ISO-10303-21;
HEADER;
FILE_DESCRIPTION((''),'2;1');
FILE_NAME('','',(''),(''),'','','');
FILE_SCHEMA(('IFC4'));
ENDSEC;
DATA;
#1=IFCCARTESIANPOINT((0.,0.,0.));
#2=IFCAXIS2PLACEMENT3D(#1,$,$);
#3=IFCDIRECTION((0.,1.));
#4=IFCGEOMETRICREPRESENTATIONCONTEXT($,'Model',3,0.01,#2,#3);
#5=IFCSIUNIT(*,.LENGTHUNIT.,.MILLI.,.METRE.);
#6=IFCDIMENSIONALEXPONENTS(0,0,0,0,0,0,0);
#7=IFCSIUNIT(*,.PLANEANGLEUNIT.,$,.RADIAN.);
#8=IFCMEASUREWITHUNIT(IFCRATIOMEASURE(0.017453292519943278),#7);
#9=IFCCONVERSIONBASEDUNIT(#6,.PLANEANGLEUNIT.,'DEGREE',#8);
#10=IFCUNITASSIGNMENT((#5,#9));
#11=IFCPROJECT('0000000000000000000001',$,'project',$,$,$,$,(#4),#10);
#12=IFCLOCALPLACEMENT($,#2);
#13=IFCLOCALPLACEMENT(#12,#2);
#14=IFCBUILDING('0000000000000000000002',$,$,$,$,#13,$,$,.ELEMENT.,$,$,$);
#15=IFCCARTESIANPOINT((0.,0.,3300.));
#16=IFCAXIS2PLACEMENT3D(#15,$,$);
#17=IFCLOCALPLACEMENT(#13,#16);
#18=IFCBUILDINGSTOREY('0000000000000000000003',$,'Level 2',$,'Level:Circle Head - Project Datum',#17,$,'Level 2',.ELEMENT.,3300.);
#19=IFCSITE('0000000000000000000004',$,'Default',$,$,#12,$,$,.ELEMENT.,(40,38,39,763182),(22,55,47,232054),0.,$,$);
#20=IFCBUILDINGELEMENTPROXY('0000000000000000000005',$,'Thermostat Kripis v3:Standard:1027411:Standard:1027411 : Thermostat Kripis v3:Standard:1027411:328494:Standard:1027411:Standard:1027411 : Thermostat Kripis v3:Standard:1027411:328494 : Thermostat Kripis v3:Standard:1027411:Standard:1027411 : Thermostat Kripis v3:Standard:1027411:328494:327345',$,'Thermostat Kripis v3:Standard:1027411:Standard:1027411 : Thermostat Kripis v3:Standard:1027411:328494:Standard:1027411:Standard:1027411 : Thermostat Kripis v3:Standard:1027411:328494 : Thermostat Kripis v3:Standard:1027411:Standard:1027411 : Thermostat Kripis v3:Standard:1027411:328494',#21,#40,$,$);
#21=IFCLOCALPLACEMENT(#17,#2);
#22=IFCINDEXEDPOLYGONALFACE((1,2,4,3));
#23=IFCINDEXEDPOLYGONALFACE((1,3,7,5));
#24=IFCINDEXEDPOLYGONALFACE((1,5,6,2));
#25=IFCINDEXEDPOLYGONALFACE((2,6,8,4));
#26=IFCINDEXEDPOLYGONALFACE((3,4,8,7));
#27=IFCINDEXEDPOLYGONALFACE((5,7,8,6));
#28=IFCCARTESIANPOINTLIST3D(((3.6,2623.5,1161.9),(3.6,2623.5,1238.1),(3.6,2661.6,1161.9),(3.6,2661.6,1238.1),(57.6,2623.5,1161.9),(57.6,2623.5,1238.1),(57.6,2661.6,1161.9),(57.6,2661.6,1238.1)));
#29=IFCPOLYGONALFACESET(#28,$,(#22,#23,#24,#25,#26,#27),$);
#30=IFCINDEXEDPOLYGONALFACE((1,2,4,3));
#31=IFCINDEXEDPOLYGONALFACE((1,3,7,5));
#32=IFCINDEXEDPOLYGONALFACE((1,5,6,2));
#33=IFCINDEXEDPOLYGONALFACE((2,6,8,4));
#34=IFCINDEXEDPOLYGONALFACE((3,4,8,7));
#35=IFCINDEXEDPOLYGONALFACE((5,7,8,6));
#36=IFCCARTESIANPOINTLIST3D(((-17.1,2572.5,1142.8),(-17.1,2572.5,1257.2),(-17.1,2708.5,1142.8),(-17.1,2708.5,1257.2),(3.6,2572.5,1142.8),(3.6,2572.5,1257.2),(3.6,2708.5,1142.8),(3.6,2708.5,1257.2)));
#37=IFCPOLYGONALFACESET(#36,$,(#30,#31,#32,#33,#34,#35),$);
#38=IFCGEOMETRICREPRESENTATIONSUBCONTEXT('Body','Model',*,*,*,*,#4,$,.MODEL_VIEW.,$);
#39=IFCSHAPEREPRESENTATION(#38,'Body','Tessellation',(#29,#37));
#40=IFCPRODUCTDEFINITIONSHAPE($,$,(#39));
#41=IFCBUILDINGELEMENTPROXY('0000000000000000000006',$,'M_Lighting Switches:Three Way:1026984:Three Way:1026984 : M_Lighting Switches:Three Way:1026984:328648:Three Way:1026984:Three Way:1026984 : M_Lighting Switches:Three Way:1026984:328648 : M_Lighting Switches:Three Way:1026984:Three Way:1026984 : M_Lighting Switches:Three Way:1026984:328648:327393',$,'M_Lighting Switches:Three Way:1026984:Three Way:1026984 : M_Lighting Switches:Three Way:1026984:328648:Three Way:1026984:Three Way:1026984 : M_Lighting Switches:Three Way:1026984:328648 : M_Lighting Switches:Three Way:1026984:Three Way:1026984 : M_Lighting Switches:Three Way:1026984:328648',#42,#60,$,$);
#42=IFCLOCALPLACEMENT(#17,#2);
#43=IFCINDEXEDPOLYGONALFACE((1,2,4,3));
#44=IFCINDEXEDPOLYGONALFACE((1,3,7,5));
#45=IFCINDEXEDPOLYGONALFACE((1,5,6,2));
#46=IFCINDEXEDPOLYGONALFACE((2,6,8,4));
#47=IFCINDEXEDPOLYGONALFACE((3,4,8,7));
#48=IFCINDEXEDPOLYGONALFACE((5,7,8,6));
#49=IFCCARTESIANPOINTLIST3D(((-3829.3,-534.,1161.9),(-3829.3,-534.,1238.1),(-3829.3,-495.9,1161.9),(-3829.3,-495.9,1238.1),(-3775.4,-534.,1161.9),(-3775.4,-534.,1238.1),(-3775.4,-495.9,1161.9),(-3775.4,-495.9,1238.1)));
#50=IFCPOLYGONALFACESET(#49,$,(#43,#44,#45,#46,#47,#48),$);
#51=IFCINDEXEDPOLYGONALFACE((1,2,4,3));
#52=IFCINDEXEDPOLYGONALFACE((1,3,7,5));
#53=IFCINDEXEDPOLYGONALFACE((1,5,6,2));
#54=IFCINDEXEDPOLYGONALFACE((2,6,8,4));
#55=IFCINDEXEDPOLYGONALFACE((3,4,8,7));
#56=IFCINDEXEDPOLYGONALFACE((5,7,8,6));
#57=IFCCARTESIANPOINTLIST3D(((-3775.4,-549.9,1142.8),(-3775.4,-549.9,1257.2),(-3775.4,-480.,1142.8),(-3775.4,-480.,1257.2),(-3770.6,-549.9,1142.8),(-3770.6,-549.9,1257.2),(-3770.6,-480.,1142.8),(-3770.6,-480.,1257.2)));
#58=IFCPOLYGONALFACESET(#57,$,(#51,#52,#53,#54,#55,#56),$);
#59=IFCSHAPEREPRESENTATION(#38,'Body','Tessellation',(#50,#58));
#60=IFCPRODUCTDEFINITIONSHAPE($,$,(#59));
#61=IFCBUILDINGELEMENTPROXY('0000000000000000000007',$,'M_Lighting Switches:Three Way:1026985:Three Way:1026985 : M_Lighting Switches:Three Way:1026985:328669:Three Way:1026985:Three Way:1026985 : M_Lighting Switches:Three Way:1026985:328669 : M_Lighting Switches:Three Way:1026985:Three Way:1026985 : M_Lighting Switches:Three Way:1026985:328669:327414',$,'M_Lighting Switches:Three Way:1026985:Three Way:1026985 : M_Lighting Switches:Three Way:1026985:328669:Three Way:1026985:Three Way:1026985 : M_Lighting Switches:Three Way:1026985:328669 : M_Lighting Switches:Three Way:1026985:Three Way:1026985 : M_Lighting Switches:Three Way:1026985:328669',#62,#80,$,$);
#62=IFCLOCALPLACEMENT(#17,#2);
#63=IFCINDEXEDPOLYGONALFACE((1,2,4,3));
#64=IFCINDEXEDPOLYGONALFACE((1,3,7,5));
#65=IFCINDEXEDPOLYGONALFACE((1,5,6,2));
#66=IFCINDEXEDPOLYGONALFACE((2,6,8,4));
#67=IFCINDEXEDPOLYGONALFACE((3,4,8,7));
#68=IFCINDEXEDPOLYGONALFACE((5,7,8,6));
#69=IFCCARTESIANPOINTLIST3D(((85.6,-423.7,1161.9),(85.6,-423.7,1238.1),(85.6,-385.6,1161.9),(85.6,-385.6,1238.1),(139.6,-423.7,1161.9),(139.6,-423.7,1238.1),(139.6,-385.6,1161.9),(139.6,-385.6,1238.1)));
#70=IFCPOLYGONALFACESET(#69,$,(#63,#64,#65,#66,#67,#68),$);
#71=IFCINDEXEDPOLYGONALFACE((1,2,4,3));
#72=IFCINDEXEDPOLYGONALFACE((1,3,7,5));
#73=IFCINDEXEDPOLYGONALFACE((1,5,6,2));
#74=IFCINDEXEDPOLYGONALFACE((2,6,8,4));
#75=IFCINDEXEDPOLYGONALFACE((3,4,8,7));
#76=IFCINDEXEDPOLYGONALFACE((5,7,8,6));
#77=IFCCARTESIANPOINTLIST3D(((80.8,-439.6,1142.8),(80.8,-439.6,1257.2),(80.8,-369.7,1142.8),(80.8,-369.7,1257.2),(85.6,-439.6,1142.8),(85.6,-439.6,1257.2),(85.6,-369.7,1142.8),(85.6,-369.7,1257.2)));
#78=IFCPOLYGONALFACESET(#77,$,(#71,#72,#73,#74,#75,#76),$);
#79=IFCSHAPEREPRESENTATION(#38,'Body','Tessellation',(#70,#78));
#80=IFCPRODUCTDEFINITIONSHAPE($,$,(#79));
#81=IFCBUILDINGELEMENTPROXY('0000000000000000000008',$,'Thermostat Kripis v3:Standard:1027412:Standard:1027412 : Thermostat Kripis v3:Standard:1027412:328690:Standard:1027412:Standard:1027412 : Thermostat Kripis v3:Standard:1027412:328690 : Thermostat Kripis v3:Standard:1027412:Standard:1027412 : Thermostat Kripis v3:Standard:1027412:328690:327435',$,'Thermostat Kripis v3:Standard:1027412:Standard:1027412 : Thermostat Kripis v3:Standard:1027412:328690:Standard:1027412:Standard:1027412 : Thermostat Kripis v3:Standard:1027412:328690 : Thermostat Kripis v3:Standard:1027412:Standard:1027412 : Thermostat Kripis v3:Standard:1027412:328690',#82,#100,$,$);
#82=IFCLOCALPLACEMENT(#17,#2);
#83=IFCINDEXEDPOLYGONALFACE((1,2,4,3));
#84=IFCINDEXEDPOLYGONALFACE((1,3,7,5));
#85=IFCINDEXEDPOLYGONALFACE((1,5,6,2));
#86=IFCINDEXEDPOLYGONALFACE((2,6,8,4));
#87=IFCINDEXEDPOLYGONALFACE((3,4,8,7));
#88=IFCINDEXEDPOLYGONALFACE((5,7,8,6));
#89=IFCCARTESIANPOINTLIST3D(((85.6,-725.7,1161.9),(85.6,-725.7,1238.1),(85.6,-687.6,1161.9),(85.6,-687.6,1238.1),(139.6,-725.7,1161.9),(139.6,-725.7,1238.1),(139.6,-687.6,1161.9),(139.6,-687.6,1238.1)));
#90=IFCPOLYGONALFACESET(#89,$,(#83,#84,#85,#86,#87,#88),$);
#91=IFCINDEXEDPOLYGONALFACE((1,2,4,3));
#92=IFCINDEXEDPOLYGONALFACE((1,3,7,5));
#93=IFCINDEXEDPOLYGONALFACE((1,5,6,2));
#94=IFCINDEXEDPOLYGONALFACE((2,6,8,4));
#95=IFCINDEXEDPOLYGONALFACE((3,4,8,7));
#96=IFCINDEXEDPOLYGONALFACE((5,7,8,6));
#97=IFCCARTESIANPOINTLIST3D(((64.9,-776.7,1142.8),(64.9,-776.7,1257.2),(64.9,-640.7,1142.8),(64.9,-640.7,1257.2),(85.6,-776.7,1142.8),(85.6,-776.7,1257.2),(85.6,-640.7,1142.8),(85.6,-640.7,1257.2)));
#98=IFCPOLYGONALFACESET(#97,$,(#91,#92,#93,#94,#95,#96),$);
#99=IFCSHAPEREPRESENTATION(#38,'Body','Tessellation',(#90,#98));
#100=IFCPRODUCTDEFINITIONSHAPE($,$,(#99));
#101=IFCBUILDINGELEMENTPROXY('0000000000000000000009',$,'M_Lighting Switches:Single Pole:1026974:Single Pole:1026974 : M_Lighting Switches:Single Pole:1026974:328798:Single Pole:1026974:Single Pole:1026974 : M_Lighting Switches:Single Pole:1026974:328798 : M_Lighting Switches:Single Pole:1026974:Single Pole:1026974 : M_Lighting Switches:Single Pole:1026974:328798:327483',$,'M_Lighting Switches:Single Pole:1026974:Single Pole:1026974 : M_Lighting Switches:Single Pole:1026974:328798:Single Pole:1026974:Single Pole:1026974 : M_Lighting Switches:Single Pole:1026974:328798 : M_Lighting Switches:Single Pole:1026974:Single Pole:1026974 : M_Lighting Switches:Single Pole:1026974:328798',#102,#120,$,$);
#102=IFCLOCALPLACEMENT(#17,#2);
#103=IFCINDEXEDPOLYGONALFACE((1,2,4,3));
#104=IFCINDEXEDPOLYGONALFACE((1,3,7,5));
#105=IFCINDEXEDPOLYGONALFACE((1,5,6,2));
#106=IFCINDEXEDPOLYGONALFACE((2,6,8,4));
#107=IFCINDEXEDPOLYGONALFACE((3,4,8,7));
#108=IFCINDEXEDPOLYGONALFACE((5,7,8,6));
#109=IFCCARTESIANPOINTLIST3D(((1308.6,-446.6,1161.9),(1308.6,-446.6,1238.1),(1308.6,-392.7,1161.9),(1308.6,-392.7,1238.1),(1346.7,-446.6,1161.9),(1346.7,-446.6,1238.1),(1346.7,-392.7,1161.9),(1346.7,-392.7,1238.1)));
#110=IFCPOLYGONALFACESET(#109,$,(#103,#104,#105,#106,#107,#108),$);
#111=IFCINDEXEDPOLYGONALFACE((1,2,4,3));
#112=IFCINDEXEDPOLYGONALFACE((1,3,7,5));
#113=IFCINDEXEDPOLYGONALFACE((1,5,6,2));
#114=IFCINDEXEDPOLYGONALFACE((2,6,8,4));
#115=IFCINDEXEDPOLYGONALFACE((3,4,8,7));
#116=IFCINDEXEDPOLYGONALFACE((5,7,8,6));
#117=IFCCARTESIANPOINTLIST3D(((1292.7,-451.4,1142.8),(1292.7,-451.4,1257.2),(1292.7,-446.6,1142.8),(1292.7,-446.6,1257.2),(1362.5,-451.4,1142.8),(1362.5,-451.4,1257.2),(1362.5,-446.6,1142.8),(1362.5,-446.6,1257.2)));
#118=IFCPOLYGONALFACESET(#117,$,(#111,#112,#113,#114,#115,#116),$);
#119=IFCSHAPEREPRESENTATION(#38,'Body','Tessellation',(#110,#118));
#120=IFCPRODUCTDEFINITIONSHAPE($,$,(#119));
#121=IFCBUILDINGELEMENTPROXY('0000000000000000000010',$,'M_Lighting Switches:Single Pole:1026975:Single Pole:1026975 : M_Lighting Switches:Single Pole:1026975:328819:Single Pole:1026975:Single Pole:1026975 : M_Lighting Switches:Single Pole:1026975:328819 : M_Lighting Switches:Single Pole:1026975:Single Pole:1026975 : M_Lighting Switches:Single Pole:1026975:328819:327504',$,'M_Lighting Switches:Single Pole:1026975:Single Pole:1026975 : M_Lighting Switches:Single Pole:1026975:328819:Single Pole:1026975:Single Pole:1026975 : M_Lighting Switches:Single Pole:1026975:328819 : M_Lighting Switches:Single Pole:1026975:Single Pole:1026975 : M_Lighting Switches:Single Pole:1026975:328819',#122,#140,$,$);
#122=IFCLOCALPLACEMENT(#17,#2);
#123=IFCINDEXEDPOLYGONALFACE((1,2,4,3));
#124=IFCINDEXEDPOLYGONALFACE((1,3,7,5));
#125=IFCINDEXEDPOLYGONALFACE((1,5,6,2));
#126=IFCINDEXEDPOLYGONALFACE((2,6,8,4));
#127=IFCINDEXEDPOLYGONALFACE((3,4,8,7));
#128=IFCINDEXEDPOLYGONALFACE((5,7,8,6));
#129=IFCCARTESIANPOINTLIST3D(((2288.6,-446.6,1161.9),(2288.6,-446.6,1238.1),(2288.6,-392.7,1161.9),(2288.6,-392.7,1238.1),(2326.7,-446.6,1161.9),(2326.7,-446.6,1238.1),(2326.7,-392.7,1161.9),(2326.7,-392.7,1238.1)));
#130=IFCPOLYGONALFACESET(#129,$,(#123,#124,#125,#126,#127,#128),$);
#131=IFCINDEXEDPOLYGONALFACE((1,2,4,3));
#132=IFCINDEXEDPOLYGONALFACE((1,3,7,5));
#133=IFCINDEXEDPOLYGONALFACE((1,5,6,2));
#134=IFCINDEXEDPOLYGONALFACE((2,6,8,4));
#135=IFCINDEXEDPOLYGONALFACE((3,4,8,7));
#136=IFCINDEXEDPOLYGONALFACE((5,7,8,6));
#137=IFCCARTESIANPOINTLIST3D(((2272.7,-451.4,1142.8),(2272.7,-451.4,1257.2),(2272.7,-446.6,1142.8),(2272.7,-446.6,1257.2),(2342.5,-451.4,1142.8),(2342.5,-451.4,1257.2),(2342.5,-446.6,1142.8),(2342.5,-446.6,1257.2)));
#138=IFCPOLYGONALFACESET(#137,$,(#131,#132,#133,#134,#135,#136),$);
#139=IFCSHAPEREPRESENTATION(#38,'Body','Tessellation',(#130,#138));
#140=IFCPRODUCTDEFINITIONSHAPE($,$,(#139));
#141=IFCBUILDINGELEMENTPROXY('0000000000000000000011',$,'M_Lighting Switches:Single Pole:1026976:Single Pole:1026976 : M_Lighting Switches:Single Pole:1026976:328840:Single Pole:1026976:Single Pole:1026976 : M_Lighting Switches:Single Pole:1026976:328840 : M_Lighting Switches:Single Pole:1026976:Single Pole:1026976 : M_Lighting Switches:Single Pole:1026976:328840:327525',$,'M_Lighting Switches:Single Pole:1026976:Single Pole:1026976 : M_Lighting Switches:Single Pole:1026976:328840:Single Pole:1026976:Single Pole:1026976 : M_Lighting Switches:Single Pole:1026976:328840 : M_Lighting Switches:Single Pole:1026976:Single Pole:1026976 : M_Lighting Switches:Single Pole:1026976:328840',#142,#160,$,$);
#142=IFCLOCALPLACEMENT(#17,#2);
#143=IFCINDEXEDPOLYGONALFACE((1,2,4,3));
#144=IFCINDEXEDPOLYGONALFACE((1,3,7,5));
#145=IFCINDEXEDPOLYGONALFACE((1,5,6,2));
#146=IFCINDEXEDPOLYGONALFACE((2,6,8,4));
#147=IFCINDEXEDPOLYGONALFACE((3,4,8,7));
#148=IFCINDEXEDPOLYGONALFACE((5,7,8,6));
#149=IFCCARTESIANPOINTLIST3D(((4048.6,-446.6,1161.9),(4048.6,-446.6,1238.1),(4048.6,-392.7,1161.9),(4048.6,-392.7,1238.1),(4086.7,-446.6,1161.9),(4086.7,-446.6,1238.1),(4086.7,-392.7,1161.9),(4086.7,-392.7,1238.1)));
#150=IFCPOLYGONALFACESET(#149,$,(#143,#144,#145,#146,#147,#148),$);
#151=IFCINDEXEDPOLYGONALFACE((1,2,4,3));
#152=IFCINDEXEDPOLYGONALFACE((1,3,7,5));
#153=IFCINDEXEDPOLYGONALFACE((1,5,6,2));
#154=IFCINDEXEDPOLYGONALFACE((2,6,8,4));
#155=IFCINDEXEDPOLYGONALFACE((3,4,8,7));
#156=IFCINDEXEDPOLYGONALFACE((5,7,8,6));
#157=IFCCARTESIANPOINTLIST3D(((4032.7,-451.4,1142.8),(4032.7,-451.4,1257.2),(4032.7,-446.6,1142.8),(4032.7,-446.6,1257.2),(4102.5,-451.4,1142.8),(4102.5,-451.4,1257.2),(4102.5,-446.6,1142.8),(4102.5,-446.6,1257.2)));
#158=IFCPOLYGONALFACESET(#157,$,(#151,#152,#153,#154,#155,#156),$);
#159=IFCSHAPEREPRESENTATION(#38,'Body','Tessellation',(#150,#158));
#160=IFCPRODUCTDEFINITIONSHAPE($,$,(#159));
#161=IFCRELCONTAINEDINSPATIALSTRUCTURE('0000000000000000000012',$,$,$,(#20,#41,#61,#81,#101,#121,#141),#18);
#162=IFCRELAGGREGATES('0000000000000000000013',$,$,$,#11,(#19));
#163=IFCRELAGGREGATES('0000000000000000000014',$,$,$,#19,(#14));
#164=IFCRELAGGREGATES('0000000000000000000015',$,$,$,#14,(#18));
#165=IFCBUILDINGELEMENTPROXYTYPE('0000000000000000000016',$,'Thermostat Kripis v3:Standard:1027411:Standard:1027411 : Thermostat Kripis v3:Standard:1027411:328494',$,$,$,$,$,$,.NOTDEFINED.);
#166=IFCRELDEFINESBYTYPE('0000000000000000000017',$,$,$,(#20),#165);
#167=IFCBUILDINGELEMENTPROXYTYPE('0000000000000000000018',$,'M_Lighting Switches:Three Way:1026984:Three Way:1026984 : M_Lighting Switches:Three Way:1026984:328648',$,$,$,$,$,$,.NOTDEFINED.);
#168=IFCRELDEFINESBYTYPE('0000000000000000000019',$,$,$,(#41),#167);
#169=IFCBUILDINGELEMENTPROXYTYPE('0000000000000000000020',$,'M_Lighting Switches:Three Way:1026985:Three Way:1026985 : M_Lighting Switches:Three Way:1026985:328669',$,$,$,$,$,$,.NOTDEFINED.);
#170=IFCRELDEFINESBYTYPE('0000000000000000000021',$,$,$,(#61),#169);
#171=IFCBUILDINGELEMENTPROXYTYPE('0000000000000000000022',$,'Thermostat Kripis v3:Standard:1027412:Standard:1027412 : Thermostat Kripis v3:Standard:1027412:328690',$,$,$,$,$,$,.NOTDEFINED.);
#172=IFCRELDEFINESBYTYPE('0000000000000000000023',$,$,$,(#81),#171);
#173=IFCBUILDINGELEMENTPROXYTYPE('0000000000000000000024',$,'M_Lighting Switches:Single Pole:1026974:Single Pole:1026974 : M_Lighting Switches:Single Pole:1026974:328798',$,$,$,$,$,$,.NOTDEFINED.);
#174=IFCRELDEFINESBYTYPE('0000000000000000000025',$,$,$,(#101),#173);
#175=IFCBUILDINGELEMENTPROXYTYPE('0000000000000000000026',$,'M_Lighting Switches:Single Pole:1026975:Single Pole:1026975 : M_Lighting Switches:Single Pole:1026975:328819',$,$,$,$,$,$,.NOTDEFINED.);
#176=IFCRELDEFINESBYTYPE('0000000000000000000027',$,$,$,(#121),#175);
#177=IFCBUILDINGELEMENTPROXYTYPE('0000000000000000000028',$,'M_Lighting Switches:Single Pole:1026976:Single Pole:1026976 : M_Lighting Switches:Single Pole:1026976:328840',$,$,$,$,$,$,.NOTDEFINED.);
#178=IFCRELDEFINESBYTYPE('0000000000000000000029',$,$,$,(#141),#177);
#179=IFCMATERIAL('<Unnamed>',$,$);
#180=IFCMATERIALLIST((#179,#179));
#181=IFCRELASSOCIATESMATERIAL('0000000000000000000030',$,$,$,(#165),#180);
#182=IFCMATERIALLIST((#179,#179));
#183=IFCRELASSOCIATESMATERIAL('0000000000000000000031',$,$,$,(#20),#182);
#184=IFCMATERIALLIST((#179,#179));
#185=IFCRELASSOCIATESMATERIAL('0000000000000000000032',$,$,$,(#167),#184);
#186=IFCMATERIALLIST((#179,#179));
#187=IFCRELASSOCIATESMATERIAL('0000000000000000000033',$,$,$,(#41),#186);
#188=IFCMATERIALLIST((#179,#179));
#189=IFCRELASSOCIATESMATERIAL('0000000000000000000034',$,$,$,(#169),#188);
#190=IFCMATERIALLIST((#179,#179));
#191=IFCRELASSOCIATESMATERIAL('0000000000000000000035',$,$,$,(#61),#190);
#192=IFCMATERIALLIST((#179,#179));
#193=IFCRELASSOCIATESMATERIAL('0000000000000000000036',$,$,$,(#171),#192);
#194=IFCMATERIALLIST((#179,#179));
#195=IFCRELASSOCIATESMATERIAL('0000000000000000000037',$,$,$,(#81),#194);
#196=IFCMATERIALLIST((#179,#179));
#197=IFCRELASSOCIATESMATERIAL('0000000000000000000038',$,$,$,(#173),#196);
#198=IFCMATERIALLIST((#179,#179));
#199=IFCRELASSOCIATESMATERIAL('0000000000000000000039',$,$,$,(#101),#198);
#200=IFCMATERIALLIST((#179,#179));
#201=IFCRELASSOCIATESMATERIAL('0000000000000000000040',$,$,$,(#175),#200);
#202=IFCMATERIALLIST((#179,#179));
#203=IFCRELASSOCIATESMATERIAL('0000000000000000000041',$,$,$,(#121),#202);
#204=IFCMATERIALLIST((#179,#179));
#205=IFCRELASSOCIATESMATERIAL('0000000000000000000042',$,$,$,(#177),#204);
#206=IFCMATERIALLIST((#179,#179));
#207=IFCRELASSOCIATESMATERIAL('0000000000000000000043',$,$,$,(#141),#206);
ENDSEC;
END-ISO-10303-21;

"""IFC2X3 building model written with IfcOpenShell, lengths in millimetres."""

from ifc_helpers import new_model, entity, si_unit, converted_unit, direction, frame, frame_2d, origin, origin_2d_with_axis, place, context, subcontext, project, spatial, rectangle, extrude, source, transform, mapped, material, material_list, type_object, type_shapes, element, save


model = new_model("IFC2X3")

# Units and contexts
model_context = context("Model", 3, precision=0.01, world=origin(), true_north=direction((0.0, 1.0)))
body_context = subcontext(model_context, "Body", "Model", "MODEL_VIEW")
ifc_project = project(units=[si_unit("LENGTHUNIT", "METRE", prefix="MILLI"), converted_unit("PLANEANGLEUNIT", "DEGREE", entity("IfcRatioMeasure", 0.017453292519943278), si_unit("PLANEANGLEUNIT", "RADIAN"), dimensions=[0, 0, 0, 0, 0, 0, 0])], contexts=[model_context])

# Site, building, storey
site_placement = place(None, origin())
site = spatial("IfcSite", under=ifc_project, at=site_placement, Name="Default", CompositionType="ELEMENT", RefLatitude=(40, 38, 39, 763182), RefLongitude=(22, 55, 47, 232054), RefElevation=0.0)
building_placement = place(site_placement, origin())
building = spatial("IfcBuilding", under=site, at=building_placement, CompositionType="ELEMENT")
storey_placement = place(building_placement, frame((0.0, 0.0, 3300.0)))
storey = spatial("IfcBuildingStorey", under=building, at=storey_placement, Name="Level 2", ObjectType="Level:Circle Head - Project Datum", LongName="Level 2", CompositionType="ELEMENT", Elevation=3300.0)

# Shared definitions
ifc_material_1 = material(Name="<Unnamed>")

# Building element proxies
ifc_material_list_1 = material_list([ifc_material_1, ifc_material_1])
ifc_material_list_2 = material_list([ifc_material_1, ifc_material_1])
building_element_proxy_type_1 = type_object("IfcBuildingElementProxyType", Name="Thermostat Kripis v3:Standard:1027411:Standard:1027411 : Thermostat Kripis v3:Standard:1027411:328494", PredefinedType="NOTDEFINED", material=ifc_material_list_2)
shared_shape_1 = source(origin(), body_context, "Body", "SweptSolid", [
    extrude(rectangle(XDim=38.1, YDim=54.0, at=frame_2d((0.0, 0.0), x_axis=(1.0, 0.0))), frame((30.6, 2642.5, 4461.9), z_axis=(0.0, 0.0, 1.0), x_axis=(0.0, 1.0, 0.0)), (0.0, 0.0, 1.0), 76.2),
    extrude(rectangle(XDim=136.0, YDim=20.7, at=origin_2d_with_axis()), frame((-6.8, 2640.5, 4442.8), z_axis=(0.0, 0.0, 1.0), x_axis=(0.0, 1.0, 0.0)), (0.0, 0.0, 1.0), 114.3),
])
type_shapes(building_element_proxy_type_1, [shared_shape_1])
proxy_1_placement = place(storey_placement, frame((0.0, 0.0, -3300.0)))
element("IfcBuildingElementProxy", 1, at=proxy_1_placement, inside=storey, type_object=building_element_proxy_type_1, material=ifc_material_list_1, Name="Thermostat Kripis v3:Standard:1027411:Standard:1027411 : Thermostat Kripis v3:Standard:1027411:328494:Standard:1027411:Standard:1027411 : Thermostat Kripis v3:Standard:1027411:328494 : Thermostat Kripis v3:Standard:1027411:Standard:1027411 : Thermostat Kripis v3:Standard:1027411:328494:327345", ObjectType="Thermostat Kripis v3:Standard:1027411:Standard:1027411 : Thermostat Kripis v3:Standard:1027411:328494:Standard:1027411:Standard:1027411 : Thermostat Kripis v3:Standard:1027411:328494 : Thermostat Kripis v3:Standard:1027411:Standard:1027411 : Thermostat Kripis v3:Standard:1027411:328494", context=body_context, shape_type="MappedRepresentation", body=[
    mapped(shared_shape_1, transform((0.0, 0.0, 0.0), scale=1.0)),
])
ifc_material_list_3 = material_list([ifc_material_1, ifc_material_1])
ifc_material_list_4 = material_list([ifc_material_1, ifc_material_1])
building_element_proxy_type_2 = type_object("IfcBuildingElementProxyType", Name="M_Lighting Switches:Three Way:1026984:Three Way:1026984 : M_Lighting Switches:Three Way:1026984:328648", PredefinedType="NOTDEFINED", material=ifc_material_list_4)
shared_shape_2 = source(origin(), body_context, "Body", "SweptSolid", [
    extrude(rectangle(XDim=38.1, YDim=54.0, at=frame_2d((0.0, 0.0), x_axis=(1.0, 0.0))), frame((-3802.3, -515.0, 4461.9), z_axis=(0.0, 0.0, 1.0), x_axis=(0.0, -1.0, 0.0)), (0.0, 0.0, 1.0), 76.2),
    extrude(rectangle(XDim=69.8, YDim=4.8, at=frame_2d((0.0, 0.0), x_axis=(1.0, 0.0))), frame((-3773.0, -515.0, 4442.8), z_axis=(0.0, 0.0, 1.0), x_axis=(0.0, -1.0, 0.0)), (0.0, 0.0, 1.0), 114.3),
])
type_shapes(building_element_proxy_type_2, [shared_shape_2])
proxy_2_placement = place(storey_placement, frame((0.0, 0.0, -3300.0)))
element("IfcBuildingElementProxy", 2, at=proxy_2_placement, inside=storey, type_object=building_element_proxy_type_2, material=ifc_material_list_3, Name="M_Lighting Switches:Three Way:1026984:Three Way:1026984 : M_Lighting Switches:Three Way:1026984:328648:Three Way:1026984:Three Way:1026984 : M_Lighting Switches:Three Way:1026984:328648 : M_Lighting Switches:Three Way:1026984:Three Way:1026984 : M_Lighting Switches:Three Way:1026984:328648:327393", ObjectType="M_Lighting Switches:Three Way:1026984:Three Way:1026984 : M_Lighting Switches:Three Way:1026984:328648:Three Way:1026984:Three Way:1026984 : M_Lighting Switches:Three Way:1026984:328648 : M_Lighting Switches:Three Way:1026984:Three Way:1026984 : M_Lighting Switches:Three Way:1026984:328648", context=body_context, shape_type="MappedRepresentation", body=[
    mapped(shared_shape_2, transform((0.0, 0.0, 0.0), scale=1.0)),
])
ifc_material_list_5 = material_list([ifc_material_1, ifc_material_1])
ifc_material_list_6 = material_list([ifc_material_1, ifc_material_1])
building_element_proxy_type_3 = type_object("IfcBuildingElementProxyType", Name="M_Lighting Switches:Three Way:1026985:Three Way:1026985 : M_Lighting Switches:Three Way:1026985:328669", PredefinedType="NOTDEFINED", material=ifc_material_list_6)
shared_shape_3 = source(origin(), body_context, "Body", "SweptSolid", [
    extrude(rectangle(XDim=38.1, YDim=54.0, at=frame_2d((0.0, 0.0), x_axis=(1.0, 0.0))), frame((112.6, -404.6, 4461.9), z_axis=(0.0, 0.0, 1.0), x_axis=(0.0, 1.0, 0.0)), (0.0, 0.0, 1.0), 76.2),
    extrude(rectangle(XDim=69.8, YDim=4.8, at=frame_2d((0.0, 0.0), x_axis=(1.0, 0.0))), frame((83.2, -404.6, 4442.8), z_axis=(0.0, 0.0, 1.0), x_axis=(0.0, 1.0, 0.0)), (0.0, 0.0, 1.0), 114.3),
])
type_shapes(building_element_proxy_type_3, [shared_shape_3])
proxy_3_placement = place(storey_placement, frame((0.0, 0.0, -3300.0)))
element("IfcBuildingElementProxy", 3, at=proxy_3_placement, inside=storey, type_object=building_element_proxy_type_3, material=ifc_material_list_5, Name="M_Lighting Switches:Three Way:1026985:Three Way:1026985 : M_Lighting Switches:Three Way:1026985:328669:Three Way:1026985:Three Way:1026985 : M_Lighting Switches:Three Way:1026985:328669 : M_Lighting Switches:Three Way:1026985:Three Way:1026985 : M_Lighting Switches:Three Way:1026985:328669:327414", ObjectType="M_Lighting Switches:Three Way:1026985:Three Way:1026985 : M_Lighting Switches:Three Way:1026985:328669:Three Way:1026985:Three Way:1026985 : M_Lighting Switches:Three Way:1026985:328669 : M_Lighting Switches:Three Way:1026985:Three Way:1026985 : M_Lighting Switches:Three Way:1026985:328669", context=body_context, shape_type="MappedRepresentation", body=[
    mapped(shared_shape_3, transform((0.0, 0.0, 0.0), scale=1.0)),
])
ifc_material_list_7 = material_list([ifc_material_1, ifc_material_1])
ifc_material_list_8 = material_list([ifc_material_1, ifc_material_1])
building_element_proxy_type_4 = type_object("IfcBuildingElementProxyType", Name="Thermostat Kripis v3:Standard:1027412:Standard:1027412 : Thermostat Kripis v3:Standard:1027412:328690", PredefinedType="NOTDEFINED", material=ifc_material_list_8)
shared_shape_4 = source(origin(), body_context, "Body", "SweptSolid", [
    extrude(rectangle(XDim=38.1, YDim=54.0, at=origin_2d_with_axis()), frame((112.6, -706.6, 4461.9), z_axis=(0.0, 0.0, 1.0), x_axis=(0.0, 1.0, 0.0)), (0.0, 0.0, 1.0), 76.2),
    extrude(rectangle(XDim=136.0, YDim=20.7, at=frame_2d((0.0, 0.0), x_axis=(1.0, 0.0))), frame((75.2, -708.7, 4442.8), z_axis=(0.0, 0.0, 1.0), x_axis=(0.0, 1.0, 0.0)), (0.0, 0.0, 1.0), 114.3),
])
type_shapes(building_element_proxy_type_4, [shared_shape_4])
proxy_4_placement = place(storey_placement, frame((0.0, 0.0, -3300.0)))
element("IfcBuildingElementProxy", 4, at=proxy_4_placement, inside=storey, type_object=building_element_proxy_type_4, material=ifc_material_list_7, Name="Thermostat Kripis v3:Standard:1027412:Standard:1027412 : Thermostat Kripis v3:Standard:1027412:328690:Standard:1027412:Standard:1027412 : Thermostat Kripis v3:Standard:1027412:328690 : Thermostat Kripis v3:Standard:1027412:Standard:1027412 : Thermostat Kripis v3:Standard:1027412:328690:327435", ObjectType="Thermostat Kripis v3:Standard:1027412:Standard:1027412 : Thermostat Kripis v3:Standard:1027412:328690:Standard:1027412:Standard:1027412 : Thermostat Kripis v3:Standard:1027412:328690 : Thermostat Kripis v3:Standard:1027412:Standard:1027412 : Thermostat Kripis v3:Standard:1027412:328690", context=body_context, shape_type="MappedRepresentation", body=[
    mapped(shared_shape_4, transform((0.0, 0.0, 0.0), scale=1.0)),
])
ifc_material_list_9 = material_list([ifc_material_1, ifc_material_1])
ifc_material_list_10 = material_list([ifc_material_1, ifc_material_1])
building_element_proxy_type_5 = type_object("IfcBuildingElementProxyType", Name="M_Lighting Switches:Single Pole:1026974:Single Pole:1026974 : M_Lighting Switches:Single Pole:1026974:328798", PredefinedType="NOTDEFINED", material=ifc_material_list_10)
shared_shape_5 = source(origin(), body_context, "Body", "SweptSolid", [
    extrude(rectangle(XDim=38.1, YDim=54.0, at=frame_2d((0.0, 0.0), x_axis=(1.0, 0.0))), frame((1327.6, -419.7, 4461.9), z_axis=(0.0, 0.0, 1.0), x_axis=(-1.0, 0.0, 0.0)), (0.0, 0.0, 1.0), 76.2),
    extrude(rectangle(XDim=69.8, YDim=4.8, at=origin_2d_with_axis()), frame((1327.6, -449.0, 4442.8), z_axis=(0.0, 0.0, 1.0), x_axis=(-1.0, 0.0, 0.0)), (0.0, 0.0, 1.0), 114.3),
])
type_shapes(building_element_proxy_type_5, [shared_shape_5])
proxy_5_placement = place(storey_placement, frame((0.0, 0.0, -3300.0)))
element("IfcBuildingElementProxy", 5, at=proxy_5_placement, inside=storey, type_object=building_element_proxy_type_5, material=ifc_material_list_9, Name="M_Lighting Switches:Single Pole:1026974:Single Pole:1026974 : M_Lighting Switches:Single Pole:1026974:328798:Single Pole:1026974:Single Pole:1026974 : M_Lighting Switches:Single Pole:1026974:328798 : M_Lighting Switches:Single Pole:1026974:Single Pole:1026974 : M_Lighting Switches:Single Pole:1026974:328798:327483", ObjectType="M_Lighting Switches:Single Pole:1026974:Single Pole:1026974 : M_Lighting Switches:Single Pole:1026974:328798:Single Pole:1026974:Single Pole:1026974 : M_Lighting Switches:Single Pole:1026974:328798 : M_Lighting Switches:Single Pole:1026974:Single Pole:1026974 : M_Lighting Switches:Single Pole:1026974:328798", context=body_context, shape_type="MappedRepresentation", body=[
    mapped(shared_shape_5, transform((0.0, 0.0, 0.0), scale=1.0)),
])
ifc_material_list_11 = material_list([ifc_material_1, ifc_material_1])
ifc_material_list_12 = material_list([ifc_material_1, ifc_material_1])
building_element_proxy_type_6 = type_object("IfcBuildingElementProxyType", Name="M_Lighting Switches:Single Pole:1026975:Single Pole:1026975 : M_Lighting Switches:Single Pole:1026975:328819", PredefinedType="NOTDEFINED", material=ifc_material_list_12)
shared_shape_6 = source(origin(), body_context, "Body", "SweptSolid", [
    extrude(rectangle(XDim=38.1, YDim=54.0, at=origin_2d_with_axis()), frame((2307.6, -419.7, 4461.9), z_axis=(0.0, 0.0, 1.0), x_axis=(-1.0, 0.0, 0.0)), (0.0, 0.0, 1.0), 76.2),
    extrude(rectangle(XDim=69.8, YDim=4.8, at=frame_2d((0.0, 0.0), x_axis=(1.0, 0.0))), frame((2307.6, -449.0, 4442.8), z_axis=(0.0, 0.0, 1.0), x_axis=(-1.0, 0.0, 0.0)), (0.0, 0.0, 1.0), 114.3),
])
type_shapes(building_element_proxy_type_6, [shared_shape_6])
proxy_6_placement = place(storey_placement, frame((0.0, 0.0, -3300.0)))
element("IfcBuildingElementProxy", 6, at=proxy_6_placement, inside=storey, type_object=building_element_proxy_type_6, material=ifc_material_list_11, Name="M_Lighting Switches:Single Pole:1026975:Single Pole:1026975 : M_Lighting Switches:Single Pole:1026975:328819:Single Pole:1026975:Single Pole:1026975 : M_Lighting Switches:Single Pole:1026975:328819 : M_Lighting Switches:Single Pole:1026975:Single Pole:1026975 : M_Lighting Switches:Single Pole:1026975:328819:327504", ObjectType="M_Lighting Switches:Single Pole:1026975:Single Pole:1026975 : M_Lighting Switches:Single Pole:1026975:328819:Single Pole:1026975:Single Pole:1026975 : M_Lighting Switches:Single Pole:1026975:328819 : M_Lighting Switches:Single Pole:1026975:Single Pole:1026975 : M_Lighting Switches:Single Pole:1026975:328819", context=body_context, shape_type="MappedRepresentation", body=[
    mapped(shared_shape_6, transform((0.0, 0.0, 0.0), scale=1.0)),
])
ifc_material_list_13 = material_list([ifc_material_1, ifc_material_1])
ifc_material_list_14 = material_list([ifc_material_1, ifc_material_1])
building_element_proxy_type_7 = type_object("IfcBuildingElementProxyType", Name="M_Lighting Switches:Single Pole:1026976:Single Pole:1026976 : M_Lighting Switches:Single Pole:1026976:328840", PredefinedType="NOTDEFINED", material=ifc_material_list_14)
shared_shape_7 = source(origin(), body_context, "Body", "SweptSolid", [
    extrude(rectangle(XDim=38.1, YDim=54.0, at=frame_2d((0.0, 0.0), x_axis=(1.0, 0.0))), frame((4067.6, -419.7, 4461.9), z_axis=(0.0, 0.0, 1.0), x_axis=(-1.0, 0.0, 0.0)), (0.0, 0.0, 1.0), 76.2),
    extrude(rectangle(XDim=69.8, YDim=4.8, at=frame_2d((0.0, 0.0), x_axis=(1.0, 0.0))), frame((4067.6, -449.0, 4442.8), z_axis=(0.0, 0.0, 1.0), x_axis=(-1.0, 0.0, 0.0)), (0.0, 0.0, 1.0), 114.3),
])
type_shapes(building_element_proxy_type_7, [shared_shape_7])
proxy_7_placement = place(storey_placement, frame((0.0, 0.0, -3300.0)))
element("IfcBuildingElementProxy", 7, at=proxy_7_placement, inside=storey, type_object=building_element_proxy_type_7, material=ifc_material_list_13, Name="M_Lighting Switches:Single Pole:1026976:Single Pole:1026976 : M_Lighting Switches:Single Pole:1026976:328840:Single Pole:1026976:Single Pole:1026976 : M_Lighting Switches:Single Pole:1026976:328840 : M_Lighting Switches:Single Pole:1026976:Single Pole:1026976 : M_Lighting Switches:Single Pole:1026976:328840:327525", ObjectType="M_Lighting Switches:Single Pole:1026976:Single Pole:1026976 : M_Lighting Switches:Single Pole:1026976:328840:Single Pole:1026976:Single Pole:1026976 : M_Lighting Switches:Single Pole:1026976:328840 : M_Lighting Switches:Single Pole:1026976:Single Pole:1026976 : M_Lighting Switches:Single Pole:1026976:328840", context=body_context, shape_type="MappedRepresentation", body=[
    mapped(shared_shape_7, transform((0.0, 0.0, 0.0), scale=1.0)),
])

save(model, "model.ifc")
